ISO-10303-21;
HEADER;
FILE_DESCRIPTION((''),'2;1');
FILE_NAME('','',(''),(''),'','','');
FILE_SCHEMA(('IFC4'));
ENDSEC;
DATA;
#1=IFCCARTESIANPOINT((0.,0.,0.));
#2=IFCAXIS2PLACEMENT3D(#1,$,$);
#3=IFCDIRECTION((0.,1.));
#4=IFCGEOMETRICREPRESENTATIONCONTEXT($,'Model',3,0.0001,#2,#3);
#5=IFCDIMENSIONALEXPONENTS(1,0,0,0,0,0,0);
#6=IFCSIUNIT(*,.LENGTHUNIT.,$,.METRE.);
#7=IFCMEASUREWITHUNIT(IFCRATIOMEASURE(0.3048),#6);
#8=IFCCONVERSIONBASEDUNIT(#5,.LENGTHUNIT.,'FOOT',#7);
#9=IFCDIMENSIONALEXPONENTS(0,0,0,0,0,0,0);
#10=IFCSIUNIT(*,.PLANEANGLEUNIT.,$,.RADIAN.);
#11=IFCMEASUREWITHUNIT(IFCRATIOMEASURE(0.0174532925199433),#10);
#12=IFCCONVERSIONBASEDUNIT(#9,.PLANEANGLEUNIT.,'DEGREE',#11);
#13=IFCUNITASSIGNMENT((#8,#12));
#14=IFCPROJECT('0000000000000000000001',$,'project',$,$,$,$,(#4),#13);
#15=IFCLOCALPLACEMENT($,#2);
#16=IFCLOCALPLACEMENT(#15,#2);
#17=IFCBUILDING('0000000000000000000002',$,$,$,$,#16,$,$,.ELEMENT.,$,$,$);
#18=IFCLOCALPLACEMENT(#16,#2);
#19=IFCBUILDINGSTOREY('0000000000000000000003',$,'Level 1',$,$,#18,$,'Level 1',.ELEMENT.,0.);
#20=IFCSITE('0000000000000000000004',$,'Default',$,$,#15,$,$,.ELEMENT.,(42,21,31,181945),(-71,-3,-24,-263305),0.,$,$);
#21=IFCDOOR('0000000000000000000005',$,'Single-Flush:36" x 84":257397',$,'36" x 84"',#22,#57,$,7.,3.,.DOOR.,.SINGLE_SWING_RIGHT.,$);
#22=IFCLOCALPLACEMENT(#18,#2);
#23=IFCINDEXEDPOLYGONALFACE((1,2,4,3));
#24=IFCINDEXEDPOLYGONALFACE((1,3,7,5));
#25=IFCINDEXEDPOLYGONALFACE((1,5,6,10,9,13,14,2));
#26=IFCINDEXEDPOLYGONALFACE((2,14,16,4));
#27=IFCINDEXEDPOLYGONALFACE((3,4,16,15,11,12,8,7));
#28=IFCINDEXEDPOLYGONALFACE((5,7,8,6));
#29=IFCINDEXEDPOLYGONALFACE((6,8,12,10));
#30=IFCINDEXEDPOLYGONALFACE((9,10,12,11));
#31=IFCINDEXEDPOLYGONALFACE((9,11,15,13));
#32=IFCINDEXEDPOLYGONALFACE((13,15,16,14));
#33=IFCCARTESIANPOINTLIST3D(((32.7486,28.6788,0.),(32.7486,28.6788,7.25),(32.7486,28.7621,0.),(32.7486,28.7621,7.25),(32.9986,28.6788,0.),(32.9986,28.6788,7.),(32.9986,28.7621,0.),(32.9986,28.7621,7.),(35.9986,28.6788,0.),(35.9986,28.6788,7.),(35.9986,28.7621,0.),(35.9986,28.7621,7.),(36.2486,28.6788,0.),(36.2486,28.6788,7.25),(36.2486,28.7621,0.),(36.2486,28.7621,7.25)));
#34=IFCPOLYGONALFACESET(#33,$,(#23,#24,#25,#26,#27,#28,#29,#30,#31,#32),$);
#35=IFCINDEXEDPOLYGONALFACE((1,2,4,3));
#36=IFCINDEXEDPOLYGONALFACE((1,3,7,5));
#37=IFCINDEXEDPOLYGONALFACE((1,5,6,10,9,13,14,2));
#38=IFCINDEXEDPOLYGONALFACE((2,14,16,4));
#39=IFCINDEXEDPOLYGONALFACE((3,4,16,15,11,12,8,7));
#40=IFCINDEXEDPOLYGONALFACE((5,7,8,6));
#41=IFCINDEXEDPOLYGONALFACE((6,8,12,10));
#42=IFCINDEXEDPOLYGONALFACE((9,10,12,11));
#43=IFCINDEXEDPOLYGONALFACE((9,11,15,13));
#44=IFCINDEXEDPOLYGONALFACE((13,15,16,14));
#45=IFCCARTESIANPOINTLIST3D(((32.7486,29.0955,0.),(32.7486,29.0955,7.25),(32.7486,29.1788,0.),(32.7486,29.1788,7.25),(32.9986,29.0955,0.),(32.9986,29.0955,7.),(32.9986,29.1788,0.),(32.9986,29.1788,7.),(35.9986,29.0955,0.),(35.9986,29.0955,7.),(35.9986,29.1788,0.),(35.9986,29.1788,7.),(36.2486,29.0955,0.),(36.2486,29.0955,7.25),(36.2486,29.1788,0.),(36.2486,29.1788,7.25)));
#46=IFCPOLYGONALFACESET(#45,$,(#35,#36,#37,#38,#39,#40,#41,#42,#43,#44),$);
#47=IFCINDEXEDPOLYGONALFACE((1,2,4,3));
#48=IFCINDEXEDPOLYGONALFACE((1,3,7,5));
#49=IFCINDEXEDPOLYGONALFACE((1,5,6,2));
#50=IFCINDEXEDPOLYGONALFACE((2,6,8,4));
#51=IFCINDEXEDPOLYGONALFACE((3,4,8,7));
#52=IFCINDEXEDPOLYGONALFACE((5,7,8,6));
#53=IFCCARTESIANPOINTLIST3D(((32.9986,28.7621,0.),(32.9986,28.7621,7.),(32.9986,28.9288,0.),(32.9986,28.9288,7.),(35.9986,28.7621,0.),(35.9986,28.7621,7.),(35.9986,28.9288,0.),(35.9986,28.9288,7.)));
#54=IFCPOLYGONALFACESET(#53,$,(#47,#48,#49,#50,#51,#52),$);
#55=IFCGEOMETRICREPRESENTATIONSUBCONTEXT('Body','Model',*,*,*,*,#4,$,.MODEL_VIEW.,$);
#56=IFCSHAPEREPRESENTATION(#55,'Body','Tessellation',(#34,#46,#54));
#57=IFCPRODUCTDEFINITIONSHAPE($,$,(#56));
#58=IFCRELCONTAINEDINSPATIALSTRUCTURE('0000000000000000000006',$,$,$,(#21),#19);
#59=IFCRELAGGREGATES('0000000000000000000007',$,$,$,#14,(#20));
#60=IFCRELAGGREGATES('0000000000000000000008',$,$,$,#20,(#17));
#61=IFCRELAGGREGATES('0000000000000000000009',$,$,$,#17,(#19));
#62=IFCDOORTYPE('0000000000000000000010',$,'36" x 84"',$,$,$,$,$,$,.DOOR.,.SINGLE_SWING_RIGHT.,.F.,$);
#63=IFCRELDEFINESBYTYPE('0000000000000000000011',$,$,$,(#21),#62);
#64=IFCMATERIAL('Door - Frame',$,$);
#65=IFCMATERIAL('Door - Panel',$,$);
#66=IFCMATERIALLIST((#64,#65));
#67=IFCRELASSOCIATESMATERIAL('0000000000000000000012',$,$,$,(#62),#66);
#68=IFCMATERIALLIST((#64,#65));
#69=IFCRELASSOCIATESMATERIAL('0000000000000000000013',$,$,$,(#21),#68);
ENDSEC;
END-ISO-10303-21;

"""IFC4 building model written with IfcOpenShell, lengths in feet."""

from ifc_helpers import new_model, entity, si_unit, converted_unit, direction, frame, frame_2d, origin, place, context, subcontext, project, spatial, polyline, rectangle, outline, extrude, source, transform, mapped, material, material_list, type_object, type_shapes, element, save


model = new_model("IFC4")

# Units and contexts
model_context = context("Model", 3, precision=0.0001, world=origin(), true_north=direction((0.0, 1.0)))
body_context = subcontext(model_context, "Body", "Model", "MODEL_VIEW")
ifc_project = project(units=[converted_unit("LENGTHUNIT", "FOOT", entity("IfcRatioMeasure", 0.3048), si_unit("LENGTHUNIT", "METRE"), dimensions=[1, 0, 0, 0, 0, 0, 0]), converted_unit("PLANEANGLEUNIT", "DEGREE", entity("IfcRatioMeasure", 0.0174532925199433), si_unit("PLANEANGLEUNIT", "RADIAN"), dimensions=[0, 0, 0, 0, 0, 0, 0])], contexts=[model_context])

# Site, building, storey
site_placement = place(None, origin())
site = spatial("IfcSite", under=ifc_project, at=site_placement, Name="Default", CompositionType="ELEMENT", RefLatitude=(42, 21, 31, 181945), RefLongitude=(-71, -3, -24, -263305), RefElevation=0.0)
building_placement = place(site_placement, origin())
building = spatial("IfcBuilding", under=site, at=building_placement, CompositionType="ELEMENT")
storey_placement = place(building_placement, origin())
storey = spatial("IfcBuildingStorey", under=building, at=storey_placement, Name="Level 1", LongName="Level 1", CompositionType="ELEMENT", Elevation=0.0)

# Shared definitions
placement_1 = place(storey_placement, frame((-0.1681, 28.9288, 0.0)))

# Door
ifc_material_1 = material(Name="Door - Frame")
ifc_material_2 = material(Name="Door - Panel")
ifc_material_list_1 = material_list([ifc_material_1, ifc_material_2])
ifc_material_list_2 = material_list([ifc_material_1, ifc_material_2])
door_type = type_object("IfcDoorType", Name="36\" x 84\"", OperationType="SINGLE_SWING_RIGHT", ParameterTakesPrecedence=False, PredefinedType="DOOR", material=ifc_material_list_2)
shared_shape = source(origin(), body_context, "Body", "SweptSolid", [
    extrude(outline(polyline([(-1.75, -3.6875), (1.75, -3.6875), (1.75, 3.5625), (1.5, 3.5625), (1.5, -3.4375), (-1.5, -3.4375), (-1.5, 3.5625), (-1.75, 3.5625), (-1.75, -3.6875)])), frame((1.5, 0.3333, 3.5625), z_axis=(0.0, 1.0, 0.0), x_axis=(1.0, 0.0, 0.0)), (0.0, 0.0, 1.0), 0.0833),
    extrude(outline(polyline([(-3.6875, -1.75), (3.5625, -1.75), (3.5625, -1.5), (-3.4375, -1.5), (-3.4375, 1.5), (3.5625, 1.5), (3.5625, 1.75), (-3.6875, 1.75), (-3.6875, -1.75)])), frame((1.5, -0.0833, 3.5625), z_axis=(0.0, 1.0, 0.0), x_axis=(0.0, 0.0, -1.0)), (0.0, 0.0, 1.0), 0.0833),
    extrude(rectangle(XDim=0.1667, YDim=3.0, at=frame_2d((0.0, 0.0), x_axis=(1.0, 0.0))), frame((1.5, 0.25, 0.0), z_axis=(0.0, 0.0, 1.0), x_axis=(0.0, 1.0, 0.0)), (0.0, 0.0, 1.0), 7.0),
])
type_shapes(door_type, [shared_shape])
placement_2 = place(placement_1, frame((36.1667, 0.1667, 0.0)))
door_placement = place(placement_2, frame((0.0, 0.0, 0.0), z_axis=(0.0, 0.0, 1.0), x_axis=(-1.0, 0.0, 0.0)))
element("IfcDoor", 1, at=door_placement, inside=storey, type_object=door_type, material=ifc_material_list_1, Name="Single-Flush:36\" x 84\":257397", ObjectType="36\" x 84\"", OperationType="SINGLE_SWING_RIGHT", OverallHeight=7.0, OverallWidth=3.0, PredefinedType="DOOR", context=body_context, shape_type="MappedRepresentation", body=[
    mapped(shared_shape, transform((0.0, 0.0, 0.0), scale=1.0)),
])

save(model, "model.ifc")
